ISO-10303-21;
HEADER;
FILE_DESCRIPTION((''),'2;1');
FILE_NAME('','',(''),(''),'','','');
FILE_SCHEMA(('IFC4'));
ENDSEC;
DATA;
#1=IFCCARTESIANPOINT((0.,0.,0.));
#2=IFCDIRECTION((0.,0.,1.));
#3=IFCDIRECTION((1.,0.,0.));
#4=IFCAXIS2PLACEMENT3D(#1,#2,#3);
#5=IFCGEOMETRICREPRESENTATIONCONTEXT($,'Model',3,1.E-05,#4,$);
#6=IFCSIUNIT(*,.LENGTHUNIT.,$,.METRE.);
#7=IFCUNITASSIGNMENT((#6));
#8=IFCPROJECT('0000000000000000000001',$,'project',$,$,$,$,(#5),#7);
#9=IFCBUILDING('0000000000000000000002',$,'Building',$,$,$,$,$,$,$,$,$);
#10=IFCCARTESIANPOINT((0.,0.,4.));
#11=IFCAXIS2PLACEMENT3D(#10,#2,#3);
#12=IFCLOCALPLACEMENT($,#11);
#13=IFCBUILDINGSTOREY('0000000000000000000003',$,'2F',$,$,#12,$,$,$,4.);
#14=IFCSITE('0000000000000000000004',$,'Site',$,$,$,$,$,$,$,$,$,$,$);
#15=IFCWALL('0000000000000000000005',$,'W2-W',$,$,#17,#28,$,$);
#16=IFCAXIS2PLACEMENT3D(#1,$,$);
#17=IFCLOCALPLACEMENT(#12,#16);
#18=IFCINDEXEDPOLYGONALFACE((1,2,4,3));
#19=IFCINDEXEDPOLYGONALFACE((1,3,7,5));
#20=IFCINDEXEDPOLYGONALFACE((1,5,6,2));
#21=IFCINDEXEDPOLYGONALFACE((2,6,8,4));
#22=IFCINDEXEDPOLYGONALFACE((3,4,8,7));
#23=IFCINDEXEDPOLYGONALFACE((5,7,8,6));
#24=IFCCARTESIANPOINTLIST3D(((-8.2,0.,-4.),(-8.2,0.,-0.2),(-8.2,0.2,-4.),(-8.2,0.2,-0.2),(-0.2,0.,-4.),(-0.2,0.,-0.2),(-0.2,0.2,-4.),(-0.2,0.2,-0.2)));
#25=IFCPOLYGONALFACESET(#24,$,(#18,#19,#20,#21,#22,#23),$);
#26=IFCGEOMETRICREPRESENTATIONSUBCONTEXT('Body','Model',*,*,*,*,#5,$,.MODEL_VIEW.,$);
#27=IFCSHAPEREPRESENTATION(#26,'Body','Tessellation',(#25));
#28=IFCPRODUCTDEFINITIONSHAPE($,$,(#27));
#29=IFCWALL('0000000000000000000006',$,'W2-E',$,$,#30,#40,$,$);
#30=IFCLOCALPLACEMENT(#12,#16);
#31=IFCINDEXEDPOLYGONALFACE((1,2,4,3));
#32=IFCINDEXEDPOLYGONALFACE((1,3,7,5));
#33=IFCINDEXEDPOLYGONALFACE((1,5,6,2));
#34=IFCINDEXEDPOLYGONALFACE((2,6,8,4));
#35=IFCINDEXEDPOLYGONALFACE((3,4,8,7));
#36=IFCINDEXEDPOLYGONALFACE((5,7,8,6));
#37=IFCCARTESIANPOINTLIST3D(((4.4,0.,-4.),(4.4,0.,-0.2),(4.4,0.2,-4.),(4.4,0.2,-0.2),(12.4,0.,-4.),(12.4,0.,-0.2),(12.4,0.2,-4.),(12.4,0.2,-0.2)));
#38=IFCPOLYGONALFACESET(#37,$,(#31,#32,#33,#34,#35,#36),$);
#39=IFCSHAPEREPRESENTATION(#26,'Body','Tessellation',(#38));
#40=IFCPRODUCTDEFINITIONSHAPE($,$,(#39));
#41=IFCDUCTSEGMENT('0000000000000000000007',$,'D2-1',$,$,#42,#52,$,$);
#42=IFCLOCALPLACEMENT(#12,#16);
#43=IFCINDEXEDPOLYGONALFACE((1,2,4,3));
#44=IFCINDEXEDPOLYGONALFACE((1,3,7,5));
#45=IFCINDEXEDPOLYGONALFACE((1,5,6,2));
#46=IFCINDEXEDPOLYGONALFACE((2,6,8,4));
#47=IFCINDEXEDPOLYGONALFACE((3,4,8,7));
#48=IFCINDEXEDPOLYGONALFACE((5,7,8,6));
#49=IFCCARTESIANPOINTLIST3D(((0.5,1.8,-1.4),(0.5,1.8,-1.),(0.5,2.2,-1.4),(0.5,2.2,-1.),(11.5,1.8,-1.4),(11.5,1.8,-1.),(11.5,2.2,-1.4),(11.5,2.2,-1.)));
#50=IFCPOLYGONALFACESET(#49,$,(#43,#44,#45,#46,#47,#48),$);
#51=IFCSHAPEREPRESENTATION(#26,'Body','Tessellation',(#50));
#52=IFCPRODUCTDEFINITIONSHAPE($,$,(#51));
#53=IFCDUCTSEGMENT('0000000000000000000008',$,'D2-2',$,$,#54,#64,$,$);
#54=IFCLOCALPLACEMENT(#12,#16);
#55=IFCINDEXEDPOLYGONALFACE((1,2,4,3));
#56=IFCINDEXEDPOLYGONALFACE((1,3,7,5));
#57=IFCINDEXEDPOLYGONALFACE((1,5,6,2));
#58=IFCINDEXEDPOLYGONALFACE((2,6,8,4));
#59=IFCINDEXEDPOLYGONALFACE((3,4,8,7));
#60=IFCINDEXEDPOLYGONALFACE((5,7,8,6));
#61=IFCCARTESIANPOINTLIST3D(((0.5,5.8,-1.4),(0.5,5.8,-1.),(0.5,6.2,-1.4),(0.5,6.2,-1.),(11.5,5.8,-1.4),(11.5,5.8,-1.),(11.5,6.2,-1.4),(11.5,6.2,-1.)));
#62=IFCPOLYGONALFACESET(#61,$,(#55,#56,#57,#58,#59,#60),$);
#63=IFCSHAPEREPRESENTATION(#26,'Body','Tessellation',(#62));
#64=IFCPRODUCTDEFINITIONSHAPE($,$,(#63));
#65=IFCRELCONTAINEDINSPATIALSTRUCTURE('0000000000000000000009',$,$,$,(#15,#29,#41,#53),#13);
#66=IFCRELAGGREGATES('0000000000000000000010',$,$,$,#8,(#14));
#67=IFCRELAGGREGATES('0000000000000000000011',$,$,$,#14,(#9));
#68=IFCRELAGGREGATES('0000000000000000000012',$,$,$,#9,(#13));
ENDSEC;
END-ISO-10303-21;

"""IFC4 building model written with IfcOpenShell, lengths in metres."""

from ifc_helpers import new_model, si_unit, frame, origin_with_axes, place, context, subcontext, project, spatial, indexed_curve, outline, extrude, shape, element, save


model = new_model("IFC4")

# Units and contexts
model_context = context("Model", 3, precision=1e-05, world=origin_with_axes())
body_context = subcontext(model_context, "Body", "Model", "MODEL_VIEW")
ifc_project = project(units=[si_unit("LENGTHUNIT", "METRE")], contexts=[model_context])

# Site, building, storey
site = spatial("IfcSite", under=ifc_project, Name="Site")
building = spatial("IfcBuilding", under=site, Name="Building")
storey_placement = place(None, frame((0.0, 0.0, 4.0), z_axis=(0.0, 0.0, 1.0), x_axis=(1.0, 0.0, 0.0)))
storey = spatial("IfcBuildingStorey", under=building, at=storey_placement, Name="2F", Elevation=4.0)

# Walls
for number, where, z_axis, x_axis, name in (
    (1, (-0.2, 0.0, -4.0), (0.0, 0.0, 1.0), (0.0, 1.0, 0.0), "W2-W"),
    (2, (12.4, 0.0, -4.0), (0.0, 0.0, 1.0), (0.0, 1.0, 0.0), "W2-E"),
):
    element("IfcWall", number, at=place(storey_placement, frame(where, z_axis=z_axis, x_axis=x_axis)), inside=storey, Name=name, shapes=[
        shape(body_context, "Body", "SweptSolid", [extrude(outline(indexed_curve([(0.0, 0.0), (0.0, 8.0), (0.2, 8.0), (0.2, 0.0), (0.0, 0.0)], self_intersect=False)), origin_with_axes(), (0.0, 0.0, 1.0), 3.8)]),
        shape(body_context, "Body", "SweptSolid", [extrude(outline(indexed_curve([(0.0, 0.0), (0.0, 0.2), (8.0, 0.2), (8.0, 0.0), (0.0, 0.0)], self_intersect=False)), origin_with_axes(), (0.0, 0.0, 1.0), 3.8)]),
    ])

# Duct segments
for number, where, z_axis, x_axis, name in (
    (3, (0.5, 1.8, -1.4), (0.0, 0.0, 1.0), (1.0, 0.0, 0.0), "D2-1"),
    (4, (0.5, 5.8, -1.4), (0.0, 0.0, 1.0), (1.0, 0.0, 0.0), "D2-2"),
):
    element("IfcDuctSegment", number, at=place(storey_placement, frame(where, z_axis=z_axis, x_axis=x_axis)), inside=storey, Name=name, context=body_context, shape_type="SweptSolid", body=[
        extrude(outline(indexed_curve([(0.0, 0.0), (0.0, 0.4), (11.0, 0.4), (11.0, 0.0), (0.0, 0.0)], self_intersect=False)), origin_with_axes(), (0.0, 0.0, 1.0), 0.4),
    ])

save(model, "model.ifc")
